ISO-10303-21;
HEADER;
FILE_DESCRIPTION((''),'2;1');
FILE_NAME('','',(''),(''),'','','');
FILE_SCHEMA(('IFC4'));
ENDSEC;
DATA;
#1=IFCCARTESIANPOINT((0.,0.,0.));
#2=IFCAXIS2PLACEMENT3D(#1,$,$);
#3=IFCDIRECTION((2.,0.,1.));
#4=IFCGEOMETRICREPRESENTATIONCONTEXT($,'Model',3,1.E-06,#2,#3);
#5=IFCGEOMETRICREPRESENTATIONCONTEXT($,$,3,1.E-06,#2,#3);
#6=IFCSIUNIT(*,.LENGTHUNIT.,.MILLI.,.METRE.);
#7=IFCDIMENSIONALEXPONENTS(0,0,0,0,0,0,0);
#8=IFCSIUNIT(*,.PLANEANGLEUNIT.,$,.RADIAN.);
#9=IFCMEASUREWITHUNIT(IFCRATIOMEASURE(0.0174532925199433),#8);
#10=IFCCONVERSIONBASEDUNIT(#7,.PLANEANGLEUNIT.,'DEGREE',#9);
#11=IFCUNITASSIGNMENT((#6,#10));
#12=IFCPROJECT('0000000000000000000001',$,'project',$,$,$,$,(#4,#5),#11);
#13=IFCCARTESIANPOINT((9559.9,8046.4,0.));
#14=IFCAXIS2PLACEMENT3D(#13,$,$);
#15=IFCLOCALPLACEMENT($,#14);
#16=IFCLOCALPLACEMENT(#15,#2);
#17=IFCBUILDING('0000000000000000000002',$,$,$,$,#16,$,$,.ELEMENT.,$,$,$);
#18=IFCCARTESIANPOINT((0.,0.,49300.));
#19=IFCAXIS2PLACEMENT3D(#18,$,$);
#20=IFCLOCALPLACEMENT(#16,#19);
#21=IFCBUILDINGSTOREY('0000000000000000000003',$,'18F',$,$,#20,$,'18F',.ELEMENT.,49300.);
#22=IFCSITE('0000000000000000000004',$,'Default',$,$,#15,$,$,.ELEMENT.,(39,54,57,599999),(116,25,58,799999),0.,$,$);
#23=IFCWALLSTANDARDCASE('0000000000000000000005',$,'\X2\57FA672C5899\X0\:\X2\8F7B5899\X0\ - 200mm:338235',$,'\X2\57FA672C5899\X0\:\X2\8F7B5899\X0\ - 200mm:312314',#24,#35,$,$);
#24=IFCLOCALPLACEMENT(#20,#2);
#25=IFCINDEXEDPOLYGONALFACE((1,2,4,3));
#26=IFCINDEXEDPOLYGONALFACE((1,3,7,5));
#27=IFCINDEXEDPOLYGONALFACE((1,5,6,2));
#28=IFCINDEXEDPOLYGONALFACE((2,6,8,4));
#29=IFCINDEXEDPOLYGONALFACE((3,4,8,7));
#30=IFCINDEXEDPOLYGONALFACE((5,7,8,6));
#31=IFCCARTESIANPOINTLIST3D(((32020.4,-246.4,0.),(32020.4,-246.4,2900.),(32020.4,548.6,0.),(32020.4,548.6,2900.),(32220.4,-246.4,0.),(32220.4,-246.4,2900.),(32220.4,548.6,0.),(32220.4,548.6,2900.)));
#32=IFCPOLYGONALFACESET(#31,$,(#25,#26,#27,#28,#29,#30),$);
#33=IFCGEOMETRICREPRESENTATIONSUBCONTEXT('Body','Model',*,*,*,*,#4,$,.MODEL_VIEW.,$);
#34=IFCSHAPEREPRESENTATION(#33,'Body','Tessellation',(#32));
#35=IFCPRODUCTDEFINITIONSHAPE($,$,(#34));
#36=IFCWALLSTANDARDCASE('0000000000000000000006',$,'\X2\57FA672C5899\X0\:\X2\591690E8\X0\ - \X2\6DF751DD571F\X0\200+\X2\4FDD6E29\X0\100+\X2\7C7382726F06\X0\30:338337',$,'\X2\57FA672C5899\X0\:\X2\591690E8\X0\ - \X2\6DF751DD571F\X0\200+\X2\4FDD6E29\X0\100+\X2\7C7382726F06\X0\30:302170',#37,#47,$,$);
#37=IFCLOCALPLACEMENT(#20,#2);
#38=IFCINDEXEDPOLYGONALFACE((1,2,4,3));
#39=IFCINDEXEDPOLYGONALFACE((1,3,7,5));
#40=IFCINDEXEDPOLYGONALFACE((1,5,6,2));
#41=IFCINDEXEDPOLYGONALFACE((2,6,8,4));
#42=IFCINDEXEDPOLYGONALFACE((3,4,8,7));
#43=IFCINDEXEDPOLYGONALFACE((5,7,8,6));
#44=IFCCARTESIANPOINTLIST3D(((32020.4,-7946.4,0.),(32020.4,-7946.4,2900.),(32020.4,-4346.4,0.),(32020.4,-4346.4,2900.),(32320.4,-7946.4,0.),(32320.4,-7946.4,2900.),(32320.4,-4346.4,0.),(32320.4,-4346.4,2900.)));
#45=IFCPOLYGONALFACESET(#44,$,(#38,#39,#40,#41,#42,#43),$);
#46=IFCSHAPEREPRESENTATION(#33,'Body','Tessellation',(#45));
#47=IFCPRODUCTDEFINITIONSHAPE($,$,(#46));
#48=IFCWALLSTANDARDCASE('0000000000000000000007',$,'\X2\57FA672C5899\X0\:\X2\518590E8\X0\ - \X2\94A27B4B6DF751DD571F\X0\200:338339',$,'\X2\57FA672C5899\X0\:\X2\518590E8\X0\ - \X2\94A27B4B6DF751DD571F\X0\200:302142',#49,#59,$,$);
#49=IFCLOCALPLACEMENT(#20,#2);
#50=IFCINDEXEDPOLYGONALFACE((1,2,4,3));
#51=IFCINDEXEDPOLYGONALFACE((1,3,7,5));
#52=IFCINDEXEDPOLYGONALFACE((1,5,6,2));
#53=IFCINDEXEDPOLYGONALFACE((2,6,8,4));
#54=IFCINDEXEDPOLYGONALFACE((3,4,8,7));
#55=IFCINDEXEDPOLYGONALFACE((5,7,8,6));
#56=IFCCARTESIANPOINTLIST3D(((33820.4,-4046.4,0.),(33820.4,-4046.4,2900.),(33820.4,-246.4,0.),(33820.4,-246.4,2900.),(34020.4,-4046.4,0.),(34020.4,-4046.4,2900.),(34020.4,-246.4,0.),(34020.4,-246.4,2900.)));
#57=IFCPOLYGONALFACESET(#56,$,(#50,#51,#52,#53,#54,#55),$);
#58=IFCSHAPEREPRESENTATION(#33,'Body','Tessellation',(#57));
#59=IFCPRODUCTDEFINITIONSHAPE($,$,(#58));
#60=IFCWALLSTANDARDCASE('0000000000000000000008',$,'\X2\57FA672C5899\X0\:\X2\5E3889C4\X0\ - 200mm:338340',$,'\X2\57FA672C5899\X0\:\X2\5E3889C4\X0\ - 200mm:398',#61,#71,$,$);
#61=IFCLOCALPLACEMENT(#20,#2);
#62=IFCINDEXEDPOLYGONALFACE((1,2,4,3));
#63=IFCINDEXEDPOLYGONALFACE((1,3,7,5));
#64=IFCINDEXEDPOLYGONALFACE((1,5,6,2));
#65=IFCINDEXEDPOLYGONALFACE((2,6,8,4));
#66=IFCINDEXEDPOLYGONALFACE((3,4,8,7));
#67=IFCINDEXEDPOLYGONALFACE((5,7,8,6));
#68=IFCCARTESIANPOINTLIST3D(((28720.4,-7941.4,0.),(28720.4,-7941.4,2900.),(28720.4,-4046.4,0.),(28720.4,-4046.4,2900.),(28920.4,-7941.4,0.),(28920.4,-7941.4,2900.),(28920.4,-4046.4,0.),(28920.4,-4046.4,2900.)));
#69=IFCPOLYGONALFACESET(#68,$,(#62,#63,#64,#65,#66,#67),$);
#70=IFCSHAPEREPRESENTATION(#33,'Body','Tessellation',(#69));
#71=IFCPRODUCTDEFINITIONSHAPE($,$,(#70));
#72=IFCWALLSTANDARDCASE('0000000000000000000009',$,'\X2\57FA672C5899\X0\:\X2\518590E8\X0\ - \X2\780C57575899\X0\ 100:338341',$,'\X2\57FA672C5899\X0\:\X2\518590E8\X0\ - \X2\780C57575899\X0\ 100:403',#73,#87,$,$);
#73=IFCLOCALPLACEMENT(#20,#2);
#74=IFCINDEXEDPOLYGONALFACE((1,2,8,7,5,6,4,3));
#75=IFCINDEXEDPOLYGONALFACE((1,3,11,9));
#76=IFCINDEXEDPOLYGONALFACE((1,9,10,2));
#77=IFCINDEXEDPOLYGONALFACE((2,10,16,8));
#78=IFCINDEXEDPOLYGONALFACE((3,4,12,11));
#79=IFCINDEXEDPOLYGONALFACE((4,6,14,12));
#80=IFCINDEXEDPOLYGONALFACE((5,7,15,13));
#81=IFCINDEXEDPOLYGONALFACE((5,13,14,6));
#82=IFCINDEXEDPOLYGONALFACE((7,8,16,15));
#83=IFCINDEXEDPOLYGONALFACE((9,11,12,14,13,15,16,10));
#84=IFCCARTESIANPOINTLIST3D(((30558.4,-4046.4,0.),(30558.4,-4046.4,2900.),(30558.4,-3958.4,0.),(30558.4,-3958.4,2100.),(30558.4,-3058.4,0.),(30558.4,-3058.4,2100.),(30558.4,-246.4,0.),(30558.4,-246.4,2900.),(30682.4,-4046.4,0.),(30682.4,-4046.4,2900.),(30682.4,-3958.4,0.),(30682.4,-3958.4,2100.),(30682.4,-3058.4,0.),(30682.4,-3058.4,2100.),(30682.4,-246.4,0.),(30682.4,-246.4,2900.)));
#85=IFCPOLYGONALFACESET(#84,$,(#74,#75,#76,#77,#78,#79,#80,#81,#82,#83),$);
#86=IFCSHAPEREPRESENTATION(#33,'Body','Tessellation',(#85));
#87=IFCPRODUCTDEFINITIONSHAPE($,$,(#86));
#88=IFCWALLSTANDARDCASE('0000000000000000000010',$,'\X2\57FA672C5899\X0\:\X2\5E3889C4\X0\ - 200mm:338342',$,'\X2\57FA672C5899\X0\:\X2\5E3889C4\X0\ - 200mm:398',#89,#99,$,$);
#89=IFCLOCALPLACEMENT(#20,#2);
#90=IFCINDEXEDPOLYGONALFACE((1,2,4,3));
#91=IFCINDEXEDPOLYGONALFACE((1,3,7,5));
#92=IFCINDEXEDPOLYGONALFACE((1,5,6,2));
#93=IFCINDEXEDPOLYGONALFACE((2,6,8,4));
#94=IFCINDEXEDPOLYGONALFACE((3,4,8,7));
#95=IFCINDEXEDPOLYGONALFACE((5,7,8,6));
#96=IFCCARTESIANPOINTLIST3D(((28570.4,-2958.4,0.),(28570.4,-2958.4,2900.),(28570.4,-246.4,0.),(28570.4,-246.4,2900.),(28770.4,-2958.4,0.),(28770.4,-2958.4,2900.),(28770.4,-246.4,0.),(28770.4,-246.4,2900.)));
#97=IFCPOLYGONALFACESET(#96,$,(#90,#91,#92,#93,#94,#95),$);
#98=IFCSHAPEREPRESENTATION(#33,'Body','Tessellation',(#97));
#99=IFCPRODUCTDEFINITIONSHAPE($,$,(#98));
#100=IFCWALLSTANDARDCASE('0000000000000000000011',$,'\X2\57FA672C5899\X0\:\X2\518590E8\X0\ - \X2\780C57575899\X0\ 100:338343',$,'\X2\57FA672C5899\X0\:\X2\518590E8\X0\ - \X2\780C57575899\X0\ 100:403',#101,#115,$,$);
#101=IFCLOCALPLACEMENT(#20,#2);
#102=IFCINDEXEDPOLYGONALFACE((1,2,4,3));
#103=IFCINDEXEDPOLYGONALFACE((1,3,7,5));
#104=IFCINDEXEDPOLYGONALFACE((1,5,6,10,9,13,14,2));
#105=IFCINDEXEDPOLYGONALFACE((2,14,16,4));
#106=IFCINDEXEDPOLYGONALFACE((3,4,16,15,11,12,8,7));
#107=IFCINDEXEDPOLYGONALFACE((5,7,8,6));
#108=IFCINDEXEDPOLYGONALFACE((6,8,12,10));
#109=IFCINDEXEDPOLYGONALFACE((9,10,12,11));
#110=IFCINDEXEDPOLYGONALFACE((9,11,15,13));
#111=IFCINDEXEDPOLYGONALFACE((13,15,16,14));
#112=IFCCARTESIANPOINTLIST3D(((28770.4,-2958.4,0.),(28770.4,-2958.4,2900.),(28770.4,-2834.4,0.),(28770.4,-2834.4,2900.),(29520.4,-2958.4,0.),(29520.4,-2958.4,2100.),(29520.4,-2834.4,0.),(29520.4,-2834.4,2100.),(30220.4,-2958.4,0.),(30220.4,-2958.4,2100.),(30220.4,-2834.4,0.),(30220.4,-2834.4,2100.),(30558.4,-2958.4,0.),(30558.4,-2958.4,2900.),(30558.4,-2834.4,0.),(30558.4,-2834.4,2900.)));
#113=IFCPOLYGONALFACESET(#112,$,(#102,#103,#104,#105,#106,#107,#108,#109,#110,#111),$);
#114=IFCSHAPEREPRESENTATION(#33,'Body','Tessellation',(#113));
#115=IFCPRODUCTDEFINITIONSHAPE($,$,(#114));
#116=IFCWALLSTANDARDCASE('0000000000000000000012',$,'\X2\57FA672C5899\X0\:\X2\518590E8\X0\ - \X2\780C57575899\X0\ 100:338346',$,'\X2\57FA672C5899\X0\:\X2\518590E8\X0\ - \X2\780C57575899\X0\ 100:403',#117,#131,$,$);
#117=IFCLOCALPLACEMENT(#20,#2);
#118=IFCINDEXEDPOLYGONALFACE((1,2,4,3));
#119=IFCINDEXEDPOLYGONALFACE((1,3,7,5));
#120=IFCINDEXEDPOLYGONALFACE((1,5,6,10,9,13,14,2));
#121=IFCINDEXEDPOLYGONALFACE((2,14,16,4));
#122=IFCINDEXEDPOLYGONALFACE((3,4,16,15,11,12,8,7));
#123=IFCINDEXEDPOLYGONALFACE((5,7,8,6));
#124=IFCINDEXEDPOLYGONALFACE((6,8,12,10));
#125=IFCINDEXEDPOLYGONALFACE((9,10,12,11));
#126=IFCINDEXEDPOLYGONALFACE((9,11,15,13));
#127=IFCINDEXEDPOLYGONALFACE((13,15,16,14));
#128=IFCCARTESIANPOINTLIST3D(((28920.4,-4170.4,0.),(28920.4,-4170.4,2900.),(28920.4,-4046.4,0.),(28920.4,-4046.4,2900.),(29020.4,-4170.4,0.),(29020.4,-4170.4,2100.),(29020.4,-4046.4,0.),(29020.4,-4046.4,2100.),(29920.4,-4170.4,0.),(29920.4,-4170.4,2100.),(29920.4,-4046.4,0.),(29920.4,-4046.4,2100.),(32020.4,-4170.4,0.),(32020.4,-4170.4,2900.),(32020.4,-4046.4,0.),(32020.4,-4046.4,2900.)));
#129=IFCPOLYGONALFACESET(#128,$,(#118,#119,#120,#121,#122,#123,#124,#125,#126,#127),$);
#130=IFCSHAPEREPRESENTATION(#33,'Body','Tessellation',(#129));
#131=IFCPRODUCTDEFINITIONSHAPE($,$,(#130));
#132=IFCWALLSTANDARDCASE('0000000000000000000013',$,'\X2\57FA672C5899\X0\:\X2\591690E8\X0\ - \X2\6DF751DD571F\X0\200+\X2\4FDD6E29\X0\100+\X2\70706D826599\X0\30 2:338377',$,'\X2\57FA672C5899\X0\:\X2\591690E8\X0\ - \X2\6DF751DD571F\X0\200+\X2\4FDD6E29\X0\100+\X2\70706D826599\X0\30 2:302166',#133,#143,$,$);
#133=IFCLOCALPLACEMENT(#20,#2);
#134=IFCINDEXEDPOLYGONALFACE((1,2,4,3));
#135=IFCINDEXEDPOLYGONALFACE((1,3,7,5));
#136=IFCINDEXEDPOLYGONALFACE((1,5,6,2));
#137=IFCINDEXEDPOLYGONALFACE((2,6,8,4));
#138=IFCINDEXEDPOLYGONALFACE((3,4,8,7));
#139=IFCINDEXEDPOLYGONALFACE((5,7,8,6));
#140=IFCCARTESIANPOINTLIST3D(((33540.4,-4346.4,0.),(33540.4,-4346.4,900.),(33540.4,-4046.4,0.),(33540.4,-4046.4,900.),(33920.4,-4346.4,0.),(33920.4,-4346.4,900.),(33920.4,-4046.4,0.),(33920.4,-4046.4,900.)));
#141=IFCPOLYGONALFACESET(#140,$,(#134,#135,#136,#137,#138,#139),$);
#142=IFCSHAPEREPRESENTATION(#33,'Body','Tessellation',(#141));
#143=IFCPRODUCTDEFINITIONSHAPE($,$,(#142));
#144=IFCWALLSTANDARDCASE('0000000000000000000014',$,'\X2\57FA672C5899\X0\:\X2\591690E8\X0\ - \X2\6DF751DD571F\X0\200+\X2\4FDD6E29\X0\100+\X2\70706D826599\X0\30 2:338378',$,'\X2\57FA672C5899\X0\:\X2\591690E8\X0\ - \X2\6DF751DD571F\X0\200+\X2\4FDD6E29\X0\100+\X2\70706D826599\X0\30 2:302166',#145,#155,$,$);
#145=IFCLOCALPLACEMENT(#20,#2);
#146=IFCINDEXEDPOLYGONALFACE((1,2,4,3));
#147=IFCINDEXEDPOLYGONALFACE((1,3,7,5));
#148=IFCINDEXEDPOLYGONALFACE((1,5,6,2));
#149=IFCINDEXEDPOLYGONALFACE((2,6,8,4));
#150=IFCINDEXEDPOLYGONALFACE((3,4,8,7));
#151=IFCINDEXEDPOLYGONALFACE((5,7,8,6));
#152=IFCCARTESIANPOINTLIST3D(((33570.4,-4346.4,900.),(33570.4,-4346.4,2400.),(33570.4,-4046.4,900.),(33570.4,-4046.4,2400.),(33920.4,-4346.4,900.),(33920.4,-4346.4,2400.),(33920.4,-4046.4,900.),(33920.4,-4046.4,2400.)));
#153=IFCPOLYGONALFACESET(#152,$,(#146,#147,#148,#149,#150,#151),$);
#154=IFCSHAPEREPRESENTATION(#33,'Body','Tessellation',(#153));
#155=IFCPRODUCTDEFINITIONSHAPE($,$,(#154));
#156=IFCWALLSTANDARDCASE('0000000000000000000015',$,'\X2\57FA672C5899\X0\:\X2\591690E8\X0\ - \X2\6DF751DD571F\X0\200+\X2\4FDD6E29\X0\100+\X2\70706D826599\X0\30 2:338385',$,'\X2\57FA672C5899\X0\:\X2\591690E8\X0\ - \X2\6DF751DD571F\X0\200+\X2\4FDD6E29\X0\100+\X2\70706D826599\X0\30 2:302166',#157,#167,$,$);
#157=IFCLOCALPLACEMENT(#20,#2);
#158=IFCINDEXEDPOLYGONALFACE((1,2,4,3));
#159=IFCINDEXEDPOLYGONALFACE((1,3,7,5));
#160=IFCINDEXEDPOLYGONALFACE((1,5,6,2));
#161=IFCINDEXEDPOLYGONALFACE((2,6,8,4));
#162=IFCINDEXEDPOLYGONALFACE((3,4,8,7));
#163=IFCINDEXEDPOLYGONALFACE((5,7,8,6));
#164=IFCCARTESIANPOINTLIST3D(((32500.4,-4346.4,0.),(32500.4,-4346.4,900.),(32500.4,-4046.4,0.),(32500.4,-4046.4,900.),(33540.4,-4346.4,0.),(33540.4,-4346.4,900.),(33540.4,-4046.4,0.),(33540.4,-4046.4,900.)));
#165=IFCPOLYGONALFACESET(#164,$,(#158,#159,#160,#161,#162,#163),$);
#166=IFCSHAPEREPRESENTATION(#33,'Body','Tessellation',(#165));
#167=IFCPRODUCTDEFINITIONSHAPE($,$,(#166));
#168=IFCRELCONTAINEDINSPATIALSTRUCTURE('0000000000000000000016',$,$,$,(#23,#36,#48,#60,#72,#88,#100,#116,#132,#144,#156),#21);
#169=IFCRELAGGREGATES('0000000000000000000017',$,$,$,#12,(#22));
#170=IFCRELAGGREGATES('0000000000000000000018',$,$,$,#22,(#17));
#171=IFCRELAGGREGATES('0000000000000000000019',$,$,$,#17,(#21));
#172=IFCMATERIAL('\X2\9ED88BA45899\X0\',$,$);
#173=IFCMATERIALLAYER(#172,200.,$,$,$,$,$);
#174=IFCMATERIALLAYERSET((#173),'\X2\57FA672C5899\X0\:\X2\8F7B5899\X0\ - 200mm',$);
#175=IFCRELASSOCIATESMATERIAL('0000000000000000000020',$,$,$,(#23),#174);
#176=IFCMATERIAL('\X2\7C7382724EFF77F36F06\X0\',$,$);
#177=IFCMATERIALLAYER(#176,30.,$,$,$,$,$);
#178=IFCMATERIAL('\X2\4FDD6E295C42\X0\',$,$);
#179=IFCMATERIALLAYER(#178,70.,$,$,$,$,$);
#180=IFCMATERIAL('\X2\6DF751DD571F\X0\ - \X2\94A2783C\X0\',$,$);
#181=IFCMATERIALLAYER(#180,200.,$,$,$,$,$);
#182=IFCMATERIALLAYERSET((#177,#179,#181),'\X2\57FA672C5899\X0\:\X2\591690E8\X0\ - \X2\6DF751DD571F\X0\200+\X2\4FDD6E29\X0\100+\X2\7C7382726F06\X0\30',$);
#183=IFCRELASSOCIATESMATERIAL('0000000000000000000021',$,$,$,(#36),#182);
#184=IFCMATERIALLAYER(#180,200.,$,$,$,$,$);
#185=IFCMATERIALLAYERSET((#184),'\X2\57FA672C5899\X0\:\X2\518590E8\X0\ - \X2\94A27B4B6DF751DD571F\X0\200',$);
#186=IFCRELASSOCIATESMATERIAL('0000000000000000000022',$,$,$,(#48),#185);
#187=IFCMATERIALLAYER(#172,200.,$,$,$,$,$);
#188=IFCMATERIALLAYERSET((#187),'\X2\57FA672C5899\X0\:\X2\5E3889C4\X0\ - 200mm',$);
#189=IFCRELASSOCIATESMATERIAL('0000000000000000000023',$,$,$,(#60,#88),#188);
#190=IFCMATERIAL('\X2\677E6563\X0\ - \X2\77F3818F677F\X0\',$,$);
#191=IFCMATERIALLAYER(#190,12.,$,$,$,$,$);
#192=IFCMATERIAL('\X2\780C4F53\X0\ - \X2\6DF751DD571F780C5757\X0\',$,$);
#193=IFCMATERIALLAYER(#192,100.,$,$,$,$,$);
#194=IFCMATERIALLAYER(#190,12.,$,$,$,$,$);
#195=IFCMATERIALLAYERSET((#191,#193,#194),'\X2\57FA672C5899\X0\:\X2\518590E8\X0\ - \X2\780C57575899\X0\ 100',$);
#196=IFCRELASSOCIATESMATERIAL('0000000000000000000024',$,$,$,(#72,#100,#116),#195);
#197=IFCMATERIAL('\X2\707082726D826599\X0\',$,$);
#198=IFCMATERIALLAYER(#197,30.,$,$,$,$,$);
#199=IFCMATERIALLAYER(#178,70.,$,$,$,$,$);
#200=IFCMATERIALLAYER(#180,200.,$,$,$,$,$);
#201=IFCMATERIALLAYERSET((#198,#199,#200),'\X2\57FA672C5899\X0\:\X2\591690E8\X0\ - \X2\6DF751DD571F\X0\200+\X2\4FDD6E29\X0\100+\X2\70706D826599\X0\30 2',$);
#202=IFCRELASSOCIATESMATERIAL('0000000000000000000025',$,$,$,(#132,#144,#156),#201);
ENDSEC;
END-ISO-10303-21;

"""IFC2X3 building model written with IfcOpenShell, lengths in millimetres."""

from ifc_helpers import new_model, entity, si_unit, converted_unit, direction, frame, frame_2d, origin, place, context, subcontext, project, spatial, rectangle, extrude, material, layer, layer_set, layer_usage, element, save


model = new_model("IFC2X3")

# Units and contexts
model_context = context("Model", 3, precision=1e-06, world=origin(), true_north=direction((2.0, 0.0, 1.0)))
context_of_model = context(None, 3, precision=1e-06, world=origin(), true_north=direction((2.0, 0.0, 1.0)))
body_context = subcontext(model_context, "Body", "Model", "MODEL_VIEW")
ifc_project = project(units=[si_unit("LENGTHUNIT", "METRE", prefix="MILLI"), converted_unit("PLANEANGLEUNIT", "DEGREE", entity("IfcRatioMeasure", 0.0174532925199433), si_unit("PLANEANGLEUNIT", "RADIAN"), dimensions=[0, 0, 0, 0, 0, 0, 0])], contexts=[model_context, context_of_model])

# Site, building, storey
site_placement = place(None, frame((9559.9, 8046.4, 0.0)))
site = spatial("IfcSite", under=ifc_project, at=site_placement, Name="Default", CompositionType="ELEMENT", RefLatitude=(39, 54, 57, 599999), RefLongitude=(116, 25, 58, 799999), RefElevation=0.0)
building_placement = place(site_placement, origin())
building = spatial("IfcBuilding", under=site, at=building_placement, CompositionType="ELEMENT")
storey_placement = place(building_placement, frame((0.0, 0.0, 49300.0)))
storey = spatial("IfcBuildingStorey", under=building, at=storey_placement, Name="18F", LongName="18F", CompositionType="ELEMENT", Elevation=49300.0)

# Walls
ifc_material_1 = material(Name="默认墙")
ifc_layer_1 = layer(ifc_material_1, 200.0)
ifc_layer_set_1 = layer_set([ifc_layer_1], Name="基本墙:轻墙 - 200mm")
ifc_layer_usage_1 = layer_usage(ifc_layer_set_1, "AXIS2", "POSITIVE", -100.0)
wall_1_placement = place(storey_placement, frame((32120.4, -246.4, 0.0), z_axis=(0.0, 0.0, 1.0), x_axis=(0.0, 1.0, 0.0)))
element("IfcWallStandardCase", 1, at=wall_1_placement, inside=storey, material=ifc_layer_usage_1, Name="基本墙:轻墙 - 200mm:338235", ObjectType="基本墙:轻墙 - 200mm:312314", context=body_context, shape_type="SweptSolid", body=[
    extrude(rectangle(XDim=795.0, YDim=200.0, at=frame_2d((397.5, 0.0), x_axis=(-1.0, 0.0))), origin(), (0.0, 0.0, 1.0), 2900.0),
])
ifc_material_2 = material(Name="米色仿石漆")
ifc_layer_2 = layer(ifc_material_2, 30.0)
ifc_material_3 = material(Name="保温层")
ifc_layer_3 = layer(ifc_material_3, 70.0)
ifc_material_4 = material(Name="混凝土 - 钢砼")
ifc_layer_4 = layer(ifc_material_4, 200.0)
ifc_layer_set_2 = layer_set([ifc_layer_2, ifc_layer_3, ifc_layer_4], Name="基本墙:外部 - 混凝土200+保温100+米色漆30")
ifc_layer_usage_2 = layer_usage(ifc_layer_set_2, "AXIS2", "POSITIVE", -150.0)
wall_2_placement = place(storey_placement, frame((32170.4, -7946.4, 0.0), z_axis=(0.0, 0.0, 1.0), x_axis=(0.0, 1.0, 0.0)))
element("IfcWallStandardCase", 2, at=wall_2_placement, inside=storey, material=ifc_layer_usage_2, Name="基本墙:外部 - 混凝土200+保温100+米色漆30:338337", ObjectType="基本墙:外部 - 混凝土200+保温100+米色漆30:302170", context=body_context, shape_type="SweptSolid", body=[
    extrude(rectangle(XDim=3600.0, YDim=300.0, at=frame_2d((1800.0, 0.0), x_axis=(-1.0, 0.0))), origin(), (0.0, 0.0, 1.0), 2900.0),
])
ifc_layer_5 = layer(ifc_material_4, 200.0)
ifc_layer_set_3 = layer_set([ifc_layer_5], Name="基本墙:内部 - 钢筋混凝土200")
ifc_layer_usage_3 = layer_usage(ifc_layer_set_3, "AXIS2", "POSITIVE", -100.0)
wall_3_placement = place(storey_placement, frame((33920.4, -4046.4, 0.0), z_axis=(0.0, 0.0, 1.0), x_axis=(0.0, 1.0, 0.0)))
element("IfcWallStandardCase", 3, at=wall_3_placement, inside=storey, material=ifc_layer_usage_3, Name="基本墙:内部 - 钢筋混凝土200:338339", ObjectType="基本墙:内部 - 钢筋混凝土200:302142", context=body_context, shape_type="SweptSolid", body=[
    extrude(rectangle(XDim=3800.0, YDim=200.0, at=frame_2d((1900.0, 0.0), x_axis=(-1.0, 0.0))), origin(), (0.0, 0.0, 1.0), 2900.0),
])
ifc_layer_6 = layer(ifc_material_1, 200.0)
ifc_layer_set_4 = layer_set([ifc_layer_6], Name="基本墙:常规 - 200mm")
ifc_layer_usage_4 = layer_usage(ifc_layer_set_4, "AXIS2", "POSITIVE", -100.0)
wall_4_placement = place(storey_placement, frame((28820.4, -7941.4, 0.0), z_axis=(0.0, 0.0, 1.0), x_axis=(0.0, 1.0, 0.0)))
element("IfcWallStandardCase", 4, at=wall_4_placement, inside=storey, material=ifc_layer_usage_4, Name="基本墙:常规 - 200mm:338340", ObjectType="基本墙:常规 - 200mm:398", context=body_context, shape_type="SweptSolid", body=[
    extrude(rectangle(XDim=3895.0, YDim=200.0, at=frame_2d((1947.5, 0.0), x_axis=(-1.0, 0.0))), origin(), (0.0, 0.0, 1.0), 2900.0),
])

# Wall, opening
ifc_material_5 = material(Name="松散 - 石膏板")
ifc_layer_7 = layer(ifc_material_5, 12.0)
ifc_material_6 = material(Name="砌体 - 混凝土砌块")
ifc_layer_8 = layer(ifc_material_6, 100.0)
ifc_layer_9 = layer(ifc_material_5, 12.0)
ifc_layer_set_5 = layer_set([ifc_layer_7, ifc_layer_8, ifc_layer_9], Name="基本墙:内部 - 砌块墙 100")
ifc_layer_usage_5 = layer_usage(ifc_layer_set_5, "AXIS2", "POSITIVE", -62.0)
wall_5_placement = place(storey_placement, frame((30620.4, -246.4, 0.0), z_axis=(0.0, 0.0, 1.0), x_axis=(0.0, -1.0, 0.0)))
wall_5 = element("IfcWallStandardCase", 5, at=wall_5_placement, inside=storey, material=ifc_layer_usage_5, Name="基本墙:内部 - 砌块墙 100:338341", ObjectType="基本墙:内部 - 砌块墙 100:403", context=body_context, shape_type="SweptSolid", body=[
    extrude(rectangle(XDim=3800.0, YDim=124.0, at=frame_2d((1900.0, 0.0), x_axis=(-1.0, 0.0))), origin(), (0.0, 0.0, 1.0), 2900.0),
])
opening_1_placement = place(wall_5_placement, frame((2812.0, -62.0, 0.0)))
element("IfcOpeningElement", 6, at=opening_1_placement, cuts=wall_5, ObjectType="Opening", context=body_context, shape_type="SweptSolid", body=[
    extrude(rectangle(XDim=2100.0, YDim=900.0, at=frame_2d((1050.0, 450.0), x_axis=(1.0, 0.0))), frame((0.0, 0.0, 0.0), z_axis=(0.0, 1.0, 0.0), x_axis=(0.0, 0.0, 1.0)), (0.0, 0.0, 1.0), 124.0),
])

# Wall
ifc_layer_usage_6 = layer_usage(ifc_layer_set_4, "AXIS2", "POSITIVE", -100.0)
wall_6_placement = place(storey_placement, frame((28670.4, -246.4, 0.0), z_axis=(0.0, 0.0, 1.0), x_axis=(0.0, -1.0, 0.0)))
element("IfcWallStandardCase", 7, at=wall_6_placement, inside=storey, material=ifc_layer_usage_6, Name="基本墙:常规 - 200mm:338342", ObjectType="基本墙:常规 - 200mm:398", context=body_context, shape_type="SweptSolid", body=[
    extrude(rectangle(XDim=2712.0, YDim=200.0, at=frame_2d((1356.0, 0.0), x_axis=(-1.0, 0.0))), origin(), (0.0, 0.0, 1.0), 2900.0),
])

# Walls, openings
ifc_layer_usage_7 = layer_usage(ifc_layer_set_5, "AXIS2", "POSITIVE", -62.0)
wall_7_placement = place(storey_placement, frame((30558.4, -2896.4, 0.0), z_axis=(0.0, 0.0, 1.0), x_axis=(-1.0, 0.0, 0.0)))
wall_7 = element("IfcWallStandardCase", 8, at=wall_7_placement, inside=storey, material=ifc_layer_usage_7, Name="基本墙:内部 - 砌块墙 100:338343", ObjectType="基本墙:内部 - 砌块墙 100:403", context=body_context, shape_type="SweptSolid", body=[
    extrude(rectangle(XDim=1788.0, YDim=124.0, at=frame_2d((894.0, 0.0), x_axis=(-1.0, 0.0))), origin(), (0.0, 0.0, 1.0), 2900.0),
])
opening_2_placement = place(wall_7_placement, frame((1038.0, 62.0, 0.0)))
element("IfcOpeningElement", 9, at=opening_2_placement, cuts=wall_7, ObjectType="Opening", context=body_context, shape_type="SweptSolid", body=[
    extrude(rectangle(XDim=2100.0, YDim=700.0, at=frame_2d((1050.0, 350.0), x_axis=(1.0, 0.0))), frame((0.0, 0.0, 0.0), z_axis=(0.0, -1.0, 0.0), x_axis=(0.0, 0.0, 1.0)), (0.0, 0.0, 1.0), 124.0),
])
ifc_layer_usage_8 = layer_usage(ifc_layer_set_5, "AXIS2", "POSITIVE", -62.0)
wall_8_placement = place(storey_placement, frame((28920.4, -4108.4, 0.0)))
wall_8 = element("IfcWallStandardCase", 10, at=wall_8_placement, inside=storey, material=ifc_layer_usage_8, Name="基本墙:内部 - 砌块墙 100:338346", ObjectType="基本墙:内部 - 砌块墙 100:403", context=body_context, shape_type="SweptSolid", body=[
    extrude(rectangle(XDim=3100.0, YDim=124.0, at=frame_2d((1550.0, 0.0), x_axis=(-1.0, 0.0))), origin(), (0.0, 0.0, 1.0), 2900.0),
])
opening_3_placement = place(wall_8_placement, frame((1000.0, 62.0, 0.0)))
element("IfcOpeningElement", 11, at=opening_3_placement, cuts=wall_8, ObjectType="Opening", context=body_context, shape_type="SweptSolid", body=[
    extrude(rectangle(XDim=2100.0, YDim=900.0, at=frame_2d((1050.0, 450.0), x_axis=(1.0, 0.0))), frame((0.0, 0.0, 0.0), z_axis=(0.0, -1.0, 0.0), x_axis=(0.0, 0.0, 1.0)), (0.0, 0.0, 1.0), 124.0),
])

# Walls
ifc_material_7 = material(Name="灰色涂料")
ifc_layer_10 = layer(ifc_material_7, 30.0)
ifc_layer_11 = layer(ifc_material_3, 70.0)
ifc_layer_12 = layer(ifc_material_4, 200.0)
ifc_layer_set_6 = layer_set([ifc_layer_10, ifc_layer_11, ifc_layer_12], Name="基本墙:外部 - 混凝土200+保温100+灰涂料30 2")
ifc_layer_usage_9 = layer_usage(ifc_layer_set_6, "AXIS2", "POSITIVE", -150.0)
wall_9_placement = place(storey_placement, frame((33540.4, -4196.4, 0.0)))
element("IfcWallStandardCase", 12, at=wall_9_placement, inside=storey, material=ifc_layer_usage_9, Name="基本墙:外部 - 混凝土200+保温100+灰涂料30 2:338377", ObjectType="基本墙:外部 - 混凝土200+保温100+灰涂料30 2:302166", context=body_context, shape_type="SweptSolid", body=[
    extrude(rectangle(XDim=380.0, YDim=300.0, at=frame_2d((190.0, 0.0), x_axis=(-1.0, 0.0))), origin(), (0.0, 0.0, 1.0), 900.0),
])
ifc_layer_usage_10 = layer_usage(ifc_layer_set_6, "AXIS2", "POSITIVE", -150.0)
wall_10_placement = place(storey_placement, frame((33570.4, -4196.4, 900.0)))
element("IfcWallStandardCase", 13, at=wall_10_placement, inside=storey, material=ifc_layer_usage_10, Name="基本墙:外部 - 混凝土200+保温100+灰涂料30 2:338378", ObjectType="基本墙:外部 - 混凝土200+保温100+灰涂料30 2:302166", context=body_context, shape_type="SweptSolid", body=[
    extrude(rectangle(XDim=350.0, YDim=300.0, at=frame_2d((175.0, 0.0), x_axis=(-1.0, 0.0))), origin(), (0.0, 0.0, 1.0), 1500.0),
])

# Wall
ifc_layer_usage_11 = layer_usage(ifc_layer_set_6, "AXIS2", "POSITIVE", -150.0)
wall_11_placement = place(storey_placement, frame((32500.4, -4196.4, 0.0)))
element("IfcWallStandardCase", 14, at=wall_11_placement, inside=storey, material=ifc_layer_usage_11, Name="基本墙:外部 - 混凝土200+保温100+灰涂料30 2:338385", ObjectType="基本墙:外部 - 混凝土200+保温100+灰涂料30 2:302166", context=body_context, shape_type="SweptSolid", body=[
    extrude(rectangle(XDim=1040.0, YDim=300.0, at=frame_2d((520.0, 0.0), x_axis=(-1.0, 0.0))), origin(), (0.0, 0.0, 1.0), 900.0),
])

save(model, "model.ifc")
